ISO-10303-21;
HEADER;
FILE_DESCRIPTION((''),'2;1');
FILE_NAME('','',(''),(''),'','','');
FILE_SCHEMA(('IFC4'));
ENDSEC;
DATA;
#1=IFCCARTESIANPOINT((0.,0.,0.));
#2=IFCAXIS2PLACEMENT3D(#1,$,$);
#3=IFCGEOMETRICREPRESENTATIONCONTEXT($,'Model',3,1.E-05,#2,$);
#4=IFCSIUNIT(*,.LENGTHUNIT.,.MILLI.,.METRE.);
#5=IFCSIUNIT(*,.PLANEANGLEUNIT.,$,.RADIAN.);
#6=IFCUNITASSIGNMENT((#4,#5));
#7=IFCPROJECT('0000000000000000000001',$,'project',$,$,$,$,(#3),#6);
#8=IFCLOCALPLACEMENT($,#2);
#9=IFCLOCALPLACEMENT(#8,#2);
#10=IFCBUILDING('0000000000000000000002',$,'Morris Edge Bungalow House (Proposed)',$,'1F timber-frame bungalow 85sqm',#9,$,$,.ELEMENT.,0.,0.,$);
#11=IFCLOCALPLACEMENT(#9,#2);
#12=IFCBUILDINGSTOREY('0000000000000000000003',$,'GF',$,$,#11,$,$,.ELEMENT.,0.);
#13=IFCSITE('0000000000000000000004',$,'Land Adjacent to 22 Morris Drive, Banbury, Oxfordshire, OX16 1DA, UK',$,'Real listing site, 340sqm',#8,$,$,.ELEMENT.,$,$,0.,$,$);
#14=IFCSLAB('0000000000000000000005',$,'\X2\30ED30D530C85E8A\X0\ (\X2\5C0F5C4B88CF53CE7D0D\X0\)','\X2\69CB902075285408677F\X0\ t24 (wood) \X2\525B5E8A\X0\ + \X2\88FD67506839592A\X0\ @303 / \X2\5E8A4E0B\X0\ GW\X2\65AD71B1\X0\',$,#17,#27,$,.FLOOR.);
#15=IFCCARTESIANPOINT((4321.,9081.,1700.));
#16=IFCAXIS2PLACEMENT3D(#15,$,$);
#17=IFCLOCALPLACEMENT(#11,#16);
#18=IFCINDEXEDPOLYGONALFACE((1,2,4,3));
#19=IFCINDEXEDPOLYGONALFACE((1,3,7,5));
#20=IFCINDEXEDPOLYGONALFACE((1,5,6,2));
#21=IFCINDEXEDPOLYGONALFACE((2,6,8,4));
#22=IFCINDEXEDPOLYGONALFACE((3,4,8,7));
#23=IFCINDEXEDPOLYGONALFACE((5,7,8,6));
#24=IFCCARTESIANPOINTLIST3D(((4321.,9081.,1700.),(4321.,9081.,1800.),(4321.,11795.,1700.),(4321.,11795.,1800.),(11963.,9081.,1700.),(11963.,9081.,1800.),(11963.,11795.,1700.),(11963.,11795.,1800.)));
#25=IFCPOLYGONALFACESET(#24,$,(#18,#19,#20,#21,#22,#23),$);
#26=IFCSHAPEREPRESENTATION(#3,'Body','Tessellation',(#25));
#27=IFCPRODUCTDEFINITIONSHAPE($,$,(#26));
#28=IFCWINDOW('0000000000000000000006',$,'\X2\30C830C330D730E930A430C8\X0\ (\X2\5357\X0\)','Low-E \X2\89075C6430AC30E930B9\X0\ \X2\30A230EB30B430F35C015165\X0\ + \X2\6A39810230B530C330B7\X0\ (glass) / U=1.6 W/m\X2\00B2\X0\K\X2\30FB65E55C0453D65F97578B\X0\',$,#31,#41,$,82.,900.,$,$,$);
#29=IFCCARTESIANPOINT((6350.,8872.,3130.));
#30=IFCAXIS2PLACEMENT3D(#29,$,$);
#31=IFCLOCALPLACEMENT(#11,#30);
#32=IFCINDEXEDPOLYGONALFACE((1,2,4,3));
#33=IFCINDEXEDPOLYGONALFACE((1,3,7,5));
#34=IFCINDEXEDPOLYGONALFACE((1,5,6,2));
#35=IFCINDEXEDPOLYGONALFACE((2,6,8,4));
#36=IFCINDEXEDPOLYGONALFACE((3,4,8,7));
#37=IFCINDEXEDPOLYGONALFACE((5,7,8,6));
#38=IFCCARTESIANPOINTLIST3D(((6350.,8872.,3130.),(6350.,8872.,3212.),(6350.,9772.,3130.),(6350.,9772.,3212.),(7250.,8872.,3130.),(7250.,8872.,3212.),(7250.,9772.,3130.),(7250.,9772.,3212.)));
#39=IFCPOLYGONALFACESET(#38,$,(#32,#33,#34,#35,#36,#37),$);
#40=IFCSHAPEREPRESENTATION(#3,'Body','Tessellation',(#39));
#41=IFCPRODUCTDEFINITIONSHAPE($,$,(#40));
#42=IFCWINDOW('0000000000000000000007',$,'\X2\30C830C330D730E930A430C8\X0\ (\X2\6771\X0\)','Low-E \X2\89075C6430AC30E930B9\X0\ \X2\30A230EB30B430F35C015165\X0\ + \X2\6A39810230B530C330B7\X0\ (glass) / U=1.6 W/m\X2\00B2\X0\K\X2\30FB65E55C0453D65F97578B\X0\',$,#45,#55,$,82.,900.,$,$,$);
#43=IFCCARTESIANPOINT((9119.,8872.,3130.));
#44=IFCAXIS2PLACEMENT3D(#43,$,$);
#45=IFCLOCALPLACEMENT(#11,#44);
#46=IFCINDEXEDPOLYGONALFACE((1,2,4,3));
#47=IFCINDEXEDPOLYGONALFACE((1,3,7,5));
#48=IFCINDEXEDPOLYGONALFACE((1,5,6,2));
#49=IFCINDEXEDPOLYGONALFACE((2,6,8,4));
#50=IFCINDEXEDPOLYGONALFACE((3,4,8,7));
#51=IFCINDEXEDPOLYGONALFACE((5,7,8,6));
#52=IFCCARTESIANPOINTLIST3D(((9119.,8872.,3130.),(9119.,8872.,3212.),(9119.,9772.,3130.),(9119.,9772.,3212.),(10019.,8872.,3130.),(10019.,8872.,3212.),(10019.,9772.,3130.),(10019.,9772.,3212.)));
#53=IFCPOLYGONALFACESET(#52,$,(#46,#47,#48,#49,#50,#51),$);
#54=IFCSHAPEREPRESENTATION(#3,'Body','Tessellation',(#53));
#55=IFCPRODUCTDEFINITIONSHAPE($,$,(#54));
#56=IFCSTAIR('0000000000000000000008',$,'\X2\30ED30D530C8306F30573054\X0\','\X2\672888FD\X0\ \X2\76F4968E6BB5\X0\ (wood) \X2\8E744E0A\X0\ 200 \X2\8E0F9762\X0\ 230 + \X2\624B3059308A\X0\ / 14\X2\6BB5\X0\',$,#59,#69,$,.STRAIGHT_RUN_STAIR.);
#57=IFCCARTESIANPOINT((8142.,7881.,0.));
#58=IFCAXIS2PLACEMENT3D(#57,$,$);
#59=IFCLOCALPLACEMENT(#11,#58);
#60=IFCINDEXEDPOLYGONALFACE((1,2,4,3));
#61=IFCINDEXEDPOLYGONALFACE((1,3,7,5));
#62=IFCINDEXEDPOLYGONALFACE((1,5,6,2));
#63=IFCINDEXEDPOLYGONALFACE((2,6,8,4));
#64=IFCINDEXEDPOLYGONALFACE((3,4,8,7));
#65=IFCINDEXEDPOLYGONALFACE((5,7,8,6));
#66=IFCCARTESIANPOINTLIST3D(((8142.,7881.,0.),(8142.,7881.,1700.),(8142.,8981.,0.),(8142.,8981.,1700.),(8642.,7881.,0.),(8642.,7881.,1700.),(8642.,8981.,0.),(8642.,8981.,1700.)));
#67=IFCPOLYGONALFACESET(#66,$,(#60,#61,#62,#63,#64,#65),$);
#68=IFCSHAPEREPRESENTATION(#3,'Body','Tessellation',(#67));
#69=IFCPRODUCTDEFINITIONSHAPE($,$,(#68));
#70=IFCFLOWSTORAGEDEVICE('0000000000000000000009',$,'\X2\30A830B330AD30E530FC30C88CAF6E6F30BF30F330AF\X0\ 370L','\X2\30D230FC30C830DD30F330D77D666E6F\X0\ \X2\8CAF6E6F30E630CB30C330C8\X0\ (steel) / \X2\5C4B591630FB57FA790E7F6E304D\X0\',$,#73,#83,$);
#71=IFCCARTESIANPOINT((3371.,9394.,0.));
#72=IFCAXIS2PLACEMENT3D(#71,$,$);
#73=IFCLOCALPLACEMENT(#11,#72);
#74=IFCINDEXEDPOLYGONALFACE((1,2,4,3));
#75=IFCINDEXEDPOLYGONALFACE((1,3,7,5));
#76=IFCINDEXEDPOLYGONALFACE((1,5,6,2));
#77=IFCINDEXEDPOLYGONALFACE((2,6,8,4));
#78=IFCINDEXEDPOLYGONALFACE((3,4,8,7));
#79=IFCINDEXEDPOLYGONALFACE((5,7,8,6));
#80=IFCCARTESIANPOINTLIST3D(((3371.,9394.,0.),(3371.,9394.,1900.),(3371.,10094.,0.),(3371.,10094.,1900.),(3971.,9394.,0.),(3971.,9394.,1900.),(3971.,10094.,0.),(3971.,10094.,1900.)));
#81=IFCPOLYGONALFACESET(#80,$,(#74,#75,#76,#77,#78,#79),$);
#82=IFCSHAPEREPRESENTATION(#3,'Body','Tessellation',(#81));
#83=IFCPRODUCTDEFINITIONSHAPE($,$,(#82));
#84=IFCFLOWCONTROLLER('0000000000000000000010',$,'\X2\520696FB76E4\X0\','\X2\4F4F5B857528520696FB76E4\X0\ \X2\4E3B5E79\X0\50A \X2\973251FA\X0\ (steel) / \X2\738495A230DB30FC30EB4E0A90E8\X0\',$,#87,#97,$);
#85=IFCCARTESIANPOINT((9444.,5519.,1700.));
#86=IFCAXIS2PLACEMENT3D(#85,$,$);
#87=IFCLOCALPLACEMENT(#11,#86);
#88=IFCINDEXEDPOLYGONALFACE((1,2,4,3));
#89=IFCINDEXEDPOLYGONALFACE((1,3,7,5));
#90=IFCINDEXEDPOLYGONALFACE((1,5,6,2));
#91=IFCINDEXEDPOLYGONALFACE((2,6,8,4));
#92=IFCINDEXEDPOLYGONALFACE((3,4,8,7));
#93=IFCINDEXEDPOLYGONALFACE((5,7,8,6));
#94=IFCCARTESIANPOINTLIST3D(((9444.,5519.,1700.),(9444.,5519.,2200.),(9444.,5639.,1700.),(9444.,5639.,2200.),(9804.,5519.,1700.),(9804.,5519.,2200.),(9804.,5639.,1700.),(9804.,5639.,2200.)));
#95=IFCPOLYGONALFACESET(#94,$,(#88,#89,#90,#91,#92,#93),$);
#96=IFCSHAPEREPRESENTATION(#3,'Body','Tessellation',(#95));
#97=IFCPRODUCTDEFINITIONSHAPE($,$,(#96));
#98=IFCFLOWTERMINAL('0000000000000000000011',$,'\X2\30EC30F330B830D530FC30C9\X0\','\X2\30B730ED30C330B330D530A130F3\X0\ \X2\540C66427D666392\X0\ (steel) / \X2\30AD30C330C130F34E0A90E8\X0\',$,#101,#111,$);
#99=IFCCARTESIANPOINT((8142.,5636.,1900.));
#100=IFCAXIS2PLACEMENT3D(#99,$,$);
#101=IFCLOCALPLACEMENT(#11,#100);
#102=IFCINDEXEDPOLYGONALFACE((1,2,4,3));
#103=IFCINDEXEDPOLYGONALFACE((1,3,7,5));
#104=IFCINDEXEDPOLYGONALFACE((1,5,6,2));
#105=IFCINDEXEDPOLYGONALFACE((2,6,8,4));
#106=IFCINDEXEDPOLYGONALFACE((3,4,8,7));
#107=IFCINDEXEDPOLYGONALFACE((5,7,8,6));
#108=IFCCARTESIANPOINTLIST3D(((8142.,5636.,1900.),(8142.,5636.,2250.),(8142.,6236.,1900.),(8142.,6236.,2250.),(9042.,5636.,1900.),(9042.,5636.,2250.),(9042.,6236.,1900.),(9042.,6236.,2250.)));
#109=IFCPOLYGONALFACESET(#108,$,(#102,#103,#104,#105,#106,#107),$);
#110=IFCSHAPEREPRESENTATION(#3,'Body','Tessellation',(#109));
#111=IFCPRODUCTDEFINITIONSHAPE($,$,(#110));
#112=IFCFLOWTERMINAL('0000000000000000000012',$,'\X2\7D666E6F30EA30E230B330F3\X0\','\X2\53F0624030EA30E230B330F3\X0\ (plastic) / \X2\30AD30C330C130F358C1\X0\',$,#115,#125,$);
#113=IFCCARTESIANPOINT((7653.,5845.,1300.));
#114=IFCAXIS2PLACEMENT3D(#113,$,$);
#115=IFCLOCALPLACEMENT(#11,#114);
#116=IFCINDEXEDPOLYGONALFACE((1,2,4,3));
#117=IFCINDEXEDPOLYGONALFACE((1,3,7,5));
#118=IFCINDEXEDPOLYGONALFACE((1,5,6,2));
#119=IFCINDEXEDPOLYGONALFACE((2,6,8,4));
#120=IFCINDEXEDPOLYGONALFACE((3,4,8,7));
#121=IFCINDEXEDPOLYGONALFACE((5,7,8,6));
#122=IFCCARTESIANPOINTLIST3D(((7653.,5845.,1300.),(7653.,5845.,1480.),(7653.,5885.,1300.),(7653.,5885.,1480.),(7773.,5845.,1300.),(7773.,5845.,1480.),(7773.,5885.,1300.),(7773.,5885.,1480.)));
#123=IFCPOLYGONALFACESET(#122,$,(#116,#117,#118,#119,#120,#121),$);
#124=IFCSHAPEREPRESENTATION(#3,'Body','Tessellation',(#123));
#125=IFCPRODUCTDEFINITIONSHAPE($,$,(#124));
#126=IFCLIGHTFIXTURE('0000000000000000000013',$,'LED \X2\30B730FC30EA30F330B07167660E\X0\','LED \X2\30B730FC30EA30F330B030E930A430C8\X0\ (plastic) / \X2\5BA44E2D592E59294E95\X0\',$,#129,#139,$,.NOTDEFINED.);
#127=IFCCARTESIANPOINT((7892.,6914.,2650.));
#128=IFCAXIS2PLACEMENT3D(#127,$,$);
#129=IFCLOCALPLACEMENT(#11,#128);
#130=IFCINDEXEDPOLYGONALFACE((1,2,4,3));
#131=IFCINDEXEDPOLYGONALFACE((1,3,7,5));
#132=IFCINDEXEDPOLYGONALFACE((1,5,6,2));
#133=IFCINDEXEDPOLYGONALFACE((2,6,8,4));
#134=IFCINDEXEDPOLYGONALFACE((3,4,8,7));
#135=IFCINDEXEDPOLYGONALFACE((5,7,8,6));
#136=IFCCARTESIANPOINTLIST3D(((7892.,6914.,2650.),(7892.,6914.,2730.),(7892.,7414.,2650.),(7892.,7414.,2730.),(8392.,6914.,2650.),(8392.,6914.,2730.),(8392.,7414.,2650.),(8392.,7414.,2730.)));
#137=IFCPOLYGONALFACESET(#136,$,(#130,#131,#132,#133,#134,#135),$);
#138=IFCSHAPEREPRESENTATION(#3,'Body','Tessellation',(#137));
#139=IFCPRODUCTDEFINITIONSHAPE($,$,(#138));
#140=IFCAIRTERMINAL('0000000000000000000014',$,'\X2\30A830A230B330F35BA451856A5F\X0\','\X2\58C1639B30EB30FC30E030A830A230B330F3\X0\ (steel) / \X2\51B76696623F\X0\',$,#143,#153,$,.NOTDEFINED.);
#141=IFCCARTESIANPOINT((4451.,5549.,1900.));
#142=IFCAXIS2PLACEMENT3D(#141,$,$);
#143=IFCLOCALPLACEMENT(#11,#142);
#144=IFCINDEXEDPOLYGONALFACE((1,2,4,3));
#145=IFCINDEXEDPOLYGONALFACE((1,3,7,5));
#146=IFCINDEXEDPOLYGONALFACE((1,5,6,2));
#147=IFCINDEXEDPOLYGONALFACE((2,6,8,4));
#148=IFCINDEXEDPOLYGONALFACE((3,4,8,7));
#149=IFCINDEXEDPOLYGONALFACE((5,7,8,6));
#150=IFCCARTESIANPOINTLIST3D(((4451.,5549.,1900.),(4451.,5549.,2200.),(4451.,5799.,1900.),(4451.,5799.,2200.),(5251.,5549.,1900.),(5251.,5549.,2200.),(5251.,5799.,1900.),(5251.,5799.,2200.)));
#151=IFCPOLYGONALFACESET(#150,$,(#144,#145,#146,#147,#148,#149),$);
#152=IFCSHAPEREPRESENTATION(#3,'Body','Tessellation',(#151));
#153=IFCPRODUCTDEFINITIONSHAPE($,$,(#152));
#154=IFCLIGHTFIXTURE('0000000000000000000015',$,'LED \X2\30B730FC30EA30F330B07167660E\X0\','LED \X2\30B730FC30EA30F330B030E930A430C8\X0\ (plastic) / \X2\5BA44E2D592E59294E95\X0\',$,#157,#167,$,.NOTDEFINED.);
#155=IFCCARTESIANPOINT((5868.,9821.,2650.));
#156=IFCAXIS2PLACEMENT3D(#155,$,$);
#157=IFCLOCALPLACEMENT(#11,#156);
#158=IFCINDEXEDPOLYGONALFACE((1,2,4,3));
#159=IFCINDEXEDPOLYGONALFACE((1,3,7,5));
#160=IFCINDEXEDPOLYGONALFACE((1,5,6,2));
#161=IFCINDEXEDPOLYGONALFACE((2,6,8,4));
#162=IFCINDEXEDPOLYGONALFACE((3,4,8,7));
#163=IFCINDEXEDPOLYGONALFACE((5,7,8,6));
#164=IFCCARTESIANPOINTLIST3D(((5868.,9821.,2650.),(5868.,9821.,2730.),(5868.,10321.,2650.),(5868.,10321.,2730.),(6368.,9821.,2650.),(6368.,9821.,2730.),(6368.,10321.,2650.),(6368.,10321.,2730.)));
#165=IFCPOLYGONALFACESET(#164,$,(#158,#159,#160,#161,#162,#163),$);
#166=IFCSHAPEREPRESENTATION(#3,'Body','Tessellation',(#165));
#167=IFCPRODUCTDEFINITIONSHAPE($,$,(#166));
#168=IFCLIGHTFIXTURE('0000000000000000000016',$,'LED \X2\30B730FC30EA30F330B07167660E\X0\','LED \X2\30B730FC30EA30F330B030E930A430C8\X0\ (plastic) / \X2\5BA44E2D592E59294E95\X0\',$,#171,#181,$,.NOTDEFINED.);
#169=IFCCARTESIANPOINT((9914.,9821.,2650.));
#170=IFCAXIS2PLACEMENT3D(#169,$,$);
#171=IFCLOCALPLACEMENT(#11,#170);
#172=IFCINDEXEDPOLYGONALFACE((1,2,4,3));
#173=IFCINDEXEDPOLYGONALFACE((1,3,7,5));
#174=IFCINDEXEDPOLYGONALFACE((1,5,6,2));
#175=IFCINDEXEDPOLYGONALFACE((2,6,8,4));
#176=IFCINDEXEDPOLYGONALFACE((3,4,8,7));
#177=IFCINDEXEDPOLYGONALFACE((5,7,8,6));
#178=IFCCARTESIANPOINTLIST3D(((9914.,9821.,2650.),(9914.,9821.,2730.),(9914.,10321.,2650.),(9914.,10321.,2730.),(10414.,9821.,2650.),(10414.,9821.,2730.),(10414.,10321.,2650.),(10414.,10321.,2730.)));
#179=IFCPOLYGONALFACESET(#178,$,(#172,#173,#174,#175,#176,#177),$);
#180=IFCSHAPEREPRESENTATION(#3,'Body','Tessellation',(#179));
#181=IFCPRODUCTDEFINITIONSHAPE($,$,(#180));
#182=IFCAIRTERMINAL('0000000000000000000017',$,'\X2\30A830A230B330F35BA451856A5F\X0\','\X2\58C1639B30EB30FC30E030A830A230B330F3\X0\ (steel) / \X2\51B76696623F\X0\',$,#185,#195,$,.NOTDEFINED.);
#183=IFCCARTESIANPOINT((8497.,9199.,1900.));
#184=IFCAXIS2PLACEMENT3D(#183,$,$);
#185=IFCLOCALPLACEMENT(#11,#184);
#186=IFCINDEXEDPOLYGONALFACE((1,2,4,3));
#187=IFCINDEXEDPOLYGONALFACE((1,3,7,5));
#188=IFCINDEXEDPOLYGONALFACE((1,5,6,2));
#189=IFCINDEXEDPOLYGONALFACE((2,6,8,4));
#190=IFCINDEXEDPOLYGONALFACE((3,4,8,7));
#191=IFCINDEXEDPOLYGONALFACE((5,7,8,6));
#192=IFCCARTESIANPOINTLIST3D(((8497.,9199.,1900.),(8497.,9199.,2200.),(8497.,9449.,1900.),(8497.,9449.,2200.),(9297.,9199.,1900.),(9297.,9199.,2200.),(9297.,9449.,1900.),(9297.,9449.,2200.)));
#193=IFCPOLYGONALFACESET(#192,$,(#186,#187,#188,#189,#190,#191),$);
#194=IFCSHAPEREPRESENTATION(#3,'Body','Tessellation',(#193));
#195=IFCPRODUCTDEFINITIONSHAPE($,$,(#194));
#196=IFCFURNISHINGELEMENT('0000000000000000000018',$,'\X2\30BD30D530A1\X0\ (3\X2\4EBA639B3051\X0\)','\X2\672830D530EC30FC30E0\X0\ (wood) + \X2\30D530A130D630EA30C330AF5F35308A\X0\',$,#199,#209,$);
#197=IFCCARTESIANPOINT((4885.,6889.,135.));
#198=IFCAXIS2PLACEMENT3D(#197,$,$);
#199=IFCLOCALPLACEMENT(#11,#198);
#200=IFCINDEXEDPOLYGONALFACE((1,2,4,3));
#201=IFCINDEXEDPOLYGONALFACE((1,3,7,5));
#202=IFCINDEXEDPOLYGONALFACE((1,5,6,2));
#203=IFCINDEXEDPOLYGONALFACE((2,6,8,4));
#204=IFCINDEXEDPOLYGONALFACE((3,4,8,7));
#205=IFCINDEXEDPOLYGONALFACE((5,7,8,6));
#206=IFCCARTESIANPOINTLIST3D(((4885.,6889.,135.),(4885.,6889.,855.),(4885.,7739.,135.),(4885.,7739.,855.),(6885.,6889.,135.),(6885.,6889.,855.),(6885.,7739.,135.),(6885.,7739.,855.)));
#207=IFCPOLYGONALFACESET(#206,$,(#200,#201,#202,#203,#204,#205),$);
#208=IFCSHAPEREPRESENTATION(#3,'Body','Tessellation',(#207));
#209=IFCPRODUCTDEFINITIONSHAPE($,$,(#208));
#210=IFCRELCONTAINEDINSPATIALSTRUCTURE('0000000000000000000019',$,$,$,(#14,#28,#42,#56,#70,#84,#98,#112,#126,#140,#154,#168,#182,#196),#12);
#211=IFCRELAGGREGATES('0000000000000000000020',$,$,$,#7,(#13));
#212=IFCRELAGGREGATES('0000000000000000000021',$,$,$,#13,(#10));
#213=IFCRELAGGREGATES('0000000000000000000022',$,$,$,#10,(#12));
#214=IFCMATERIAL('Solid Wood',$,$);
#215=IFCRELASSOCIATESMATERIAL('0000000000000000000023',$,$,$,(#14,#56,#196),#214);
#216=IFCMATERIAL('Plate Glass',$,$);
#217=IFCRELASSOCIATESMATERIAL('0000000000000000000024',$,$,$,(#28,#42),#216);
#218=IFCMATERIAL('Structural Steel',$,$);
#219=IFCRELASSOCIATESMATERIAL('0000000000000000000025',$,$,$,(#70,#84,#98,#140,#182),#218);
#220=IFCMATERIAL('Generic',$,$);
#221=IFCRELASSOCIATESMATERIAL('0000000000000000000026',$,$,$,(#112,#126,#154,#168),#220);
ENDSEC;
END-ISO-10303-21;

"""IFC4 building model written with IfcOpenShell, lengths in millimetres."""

from ifc_helpers import new_model, si_unit, frame, frame_2d, origin, place, context, project, spatial, rectangle, extrude, material, element, save


model = new_model("IFC4")

# Units and contexts
model_context = context("Model", 3, precision=1e-05, world=origin())
ifc_project = project(units=[si_unit("LENGTHUNIT", "METRE", prefix="MILLI"), si_unit("PLANEANGLEUNIT", "RADIAN")], contexts=[model_context])

# Site, building, storey
site_placement = place(None, origin())
site = spatial("IfcSite", under=ifc_project, at=site_placement, Name="Land Adjacent to 22 Morris Drive, Banbury, Oxfordshire, OX16 1DA, UK", ObjectType="Real listing site, 340sqm", CompositionType="ELEMENT", RefElevation=0.0)
building_placement = place(site_placement, origin())
building = spatial("IfcBuilding", under=site, at=building_placement, Name="Morris Edge Bungalow House (Proposed)", ObjectType="1F timber-frame bungalow 85sqm", CompositionType="ELEMENT", ElevationOfRefHeight=0.0, ElevationOfTerrain=0.0)
storey_placement = place(building_placement, origin())
storey = spatial("IfcBuildingStorey", under=building, at=storey_placement, Name="GF", CompositionType="ELEMENT", Elevation=0.0)

# Shared definitions
ifc_material_1 = material(Name="Solid Wood")

# Slab
slab_placement = place(storey_placement, frame((4321.0, 9081.0, 1700.0)))
element("IfcSlab", 1, at=slab_placement, inside=storey, material=ifc_material_1, Name="ロフト床 (小屋裏収納)", Description="構造用合板 t24 (wood) 剛床 + 製材根太 @303 / 床下 GW断熱", PredefinedType="FLOOR", context=model_context, shape_type="SweptSolid", body=[
    extrude(rectangle(XDim=7642.0, YDim=2714.0, at=frame_2d((3821.0, 1357.0))), frame((4321.0, 9081.0, 1700.0)), (0.0, 0.0, 1.0), 100.0),
])

# Windows
ifc_material_2 = material(Name="Plate Glass")
window_1_placement = place(storey_placement, frame((6350.0, 8872.0, 3130.0)))
element("IfcWindow", 2, at=window_1_placement, inside=storey, material=ifc_material_2, Name="トップライト (南)", Description="Low-E 複層ガラス アルゴン封入 + 樹脂サッシ (glass) / U=1.6 W/m²K・日射取得型", OverallHeight=82.0, OverallWidth=900.0, context=model_context, shape_type="SweptSolid", body=[
    extrude(rectangle(XDim=900.0, YDim=900.0, at=frame_2d((450.0, 450.0))), frame((6350.0, 8872.0, 3130.0)), (0.0, 0.0, 1.0), 82.0),
])
window_2_placement = place(storey_placement, frame((9119.0, 8872.0, 3130.0)))
element("IfcWindow", 3, at=window_2_placement, inside=storey, material=ifc_material_2, Name="トップライト (東)", Description="Low-E 複層ガラス アルゴン封入 + 樹脂サッシ (glass) / U=1.6 W/m²K・日射取得型", OverallHeight=82.0, OverallWidth=900.0, context=model_context, shape_type="SweptSolid", body=[
    extrude(rectangle(XDim=900.0, YDim=900.0, at=frame_2d((450.0, 450.0))), frame((9119.0, 8872.0, 3130.0)), (0.0, 0.0, 1.0), 82.0),
])

# Stair
stair_placement = place(storey_placement, frame((8142.0, 7881.0, 0.0)))
element("IfcStair", 4, at=stair_placement, inside=storey, material=ifc_material_1, Name="ロフトはしご", Description="木製 直階段 (wood) 蹴上 200 踏面 230 + 手すり / 14段", PredefinedType="STRAIGHT_RUN_STAIR", context=model_context, shape_type="SweptSolid", body=[
    extrude(rectangle(XDim=500.0, YDim=1100.0, at=frame_2d((250.0, 550.0))), frame((8142.0, 7881.0, 0.0)), (0.0, 0.0, 1.0), 1700.0),
])

# Flow storage device
ifc_material_3 = material(Name="Structural Steel")
flow_storage_device_placement = place(storey_placement, frame((3371.0, 9394.0, 0.0)))
element("IfcFlowStorageDevice", 5, at=flow_storage_device_placement, inside=storey, material=ifc_material_3, Name="エコキュート貯湯タンク 370L", Description="ヒートポンプ給湯 貯湯ユニット (steel) / 屋外・基礎置き", context=model_context, shape_type="SweptSolid", body=[
    extrude(rectangle(XDim=600.0, YDim=700.0, at=frame_2d((300.0, 350.0))), frame((3371.0, 9394.0, 0.0)), (0.0, 0.0, 1.0), 1900.0),
])

# Flow controller
flow_controller_placement = place(storey_placement, frame((9444.0, 5519.0, 1700.0)))
element("IfcFlowController", 6, at=flow_controller_placement, inside=storey, material=ifc_material_3, Name="分電盤", Description="住宅用分電盤 主幹50A 露出 (steel) / 玄関ホール上部", context=model_context, shape_type="SweptSolid", body=[
    extrude(rectangle(XDim=360.0, YDim=120.0, at=frame_2d((180.0, 60.0))), frame((9444.0, 5519.0, 1700.0)), (0.0, 0.0, 1.0), 500.0),
])

# Flow terminals
flow_terminal_1_placement = place(storey_placement, frame((8142.0, 5636.0, 1900.0)))
element("IfcFlowTerminal", 7, at=flow_terminal_1_placement, inside=storey, material=ifc_material_3, Name="レンジフード", Description="シロッコファン 同時給排 (steel) / キッチン上部", context=model_context, shape_type="SweptSolid", body=[
    extrude(rectangle(XDim=900.0, YDim=600.0, at=frame_2d((450.0, 300.0))), frame((8142.0, 5636.0, 1900.0)), (0.0, 0.0, 1.0), 350.0),
])
ifc_material_4 = material(Name="Generic")
flow_terminal_2_placement = place(storey_placement, frame((7653.0, 5845.0, 1300.0)))
element("IfcFlowTerminal", 8, at=flow_terminal_2_placement, inside=storey, material=ifc_material_4, Name="給湯リモコン", Description="台所リモコン (plastic) / キッチン壁", context=model_context, shape_type="SweptSolid", body=[
    extrude(rectangle(XDim=120.0, YDim=40.0, at=frame_2d((60.0, 20.0))), frame((7653.0, 5845.0, 1300.0)), (0.0, 0.0, 1.0), 180.0),
])

# Light fixture
light_fixture_1_placement = place(storey_placement, frame((7892.0, 6914.0, 2650.0)))
element("IfcLightFixture", 9, at=light_fixture_1_placement, inside=storey, material=ifc_material_4, Name="LED シーリング照明", Description="LED シーリングライト (plastic) / 室中央天井", PredefinedType="NOTDEFINED", context=model_context, shape_type="SweptSolid", body=[
    extrude(rectangle(XDim=500.0, YDim=500.0, at=frame_2d((250.0, 250.0))), frame((7892.0, 6914.0, 2650.0)), (0.0, 0.0, 1.0), 80.0),
])

# Air terminal
air_terminal_1_placement = place(storey_placement, frame((4451.0, 5549.0, 1900.0)))
element("IfcAirTerminal", 10, at=air_terminal_1_placement, inside=storey, material=ifc_material_3, Name="エアコン室内機", Description="壁掛ルームエアコン (steel) / 冷暖房", PredefinedType="NOTDEFINED", context=model_context, shape_type="SweptSolid", body=[
    extrude(rectangle(XDim=800.0, YDim=250.0, at=frame_2d((400.0, 125.0))), frame((4451.0, 5549.0, 1900.0)), (0.0, 0.0, 1.0), 300.0),
])

# Light fixtures
light_fixture_2_placement = place(storey_placement, frame((5868.0, 9821.0, 2650.0)))
element("IfcLightFixture", 11, at=light_fixture_2_placement, inside=storey, material=ifc_material_4, Name="LED シーリング照明", Description="LED シーリングライト (plastic) / 室中央天井", PredefinedType="NOTDEFINED", context=model_context, shape_type="SweptSolid", body=[
    extrude(rectangle(XDim=500.0, YDim=500.0, at=frame_2d((250.0, 250.0))), frame((5868.0, 9821.0, 2650.0)), (0.0, 0.0, 1.0), 80.0),
])
light_fixture_3_placement = place(storey_placement, frame((9914.0, 9821.0, 2650.0)))
element("IfcLightFixture", 12, at=light_fixture_3_placement, inside=storey, material=ifc_material_4, Name="LED シーリング照明", Description="LED シーリングライト (plastic) / 室中央天井", PredefinedType="NOTDEFINED", context=model_context, shape_type="SweptSolid", body=[
    extrude(rectangle(XDim=500.0, YDim=500.0, at=frame_2d((250.0, 250.0))), frame((9914.0, 9821.0, 2650.0)), (0.0, 0.0, 1.0), 80.0),
])

# Air terminal
air_terminal_2_placement = place(storey_placement, frame((8497.0, 9199.0, 1900.0)))
element("IfcAirTerminal", 13, at=air_terminal_2_placement, inside=storey, material=ifc_material_3, Name="エアコン室内機", Description="壁掛ルームエアコン (steel) / 冷暖房", PredefinedType="NOTDEFINED", context=model_context, shape_type="SweptSolid", body=[
    extrude(rectangle(XDim=800.0, YDim=250.0, at=frame_2d((400.0, 125.0))), frame((8497.0, 9199.0, 1900.0)), (0.0, 0.0, 1.0), 300.0),
])

# Furnishing element
furnishing_1_placement = place(storey_placement, frame((4885.0, 6889.0, 135.0)))
element("IfcFurnishingElement", 14, at=furnishing_1_placement, inside=storey, material=ifc_material_1, Name="ソファ (3人掛け)", Description="木フレーム (wood) + ファブリック張り", context=model_context, shape_type="SweptSolid", body=[
    extrude(rectangle(XDim=2000.0, YDim=850.0, at=frame_2d((1000.0, 425.0))), frame((4885.0, 6889.0, 135.0)), (0.0, 0.0, 1.0), 720.0),
])

save(model, "model.ifc")
